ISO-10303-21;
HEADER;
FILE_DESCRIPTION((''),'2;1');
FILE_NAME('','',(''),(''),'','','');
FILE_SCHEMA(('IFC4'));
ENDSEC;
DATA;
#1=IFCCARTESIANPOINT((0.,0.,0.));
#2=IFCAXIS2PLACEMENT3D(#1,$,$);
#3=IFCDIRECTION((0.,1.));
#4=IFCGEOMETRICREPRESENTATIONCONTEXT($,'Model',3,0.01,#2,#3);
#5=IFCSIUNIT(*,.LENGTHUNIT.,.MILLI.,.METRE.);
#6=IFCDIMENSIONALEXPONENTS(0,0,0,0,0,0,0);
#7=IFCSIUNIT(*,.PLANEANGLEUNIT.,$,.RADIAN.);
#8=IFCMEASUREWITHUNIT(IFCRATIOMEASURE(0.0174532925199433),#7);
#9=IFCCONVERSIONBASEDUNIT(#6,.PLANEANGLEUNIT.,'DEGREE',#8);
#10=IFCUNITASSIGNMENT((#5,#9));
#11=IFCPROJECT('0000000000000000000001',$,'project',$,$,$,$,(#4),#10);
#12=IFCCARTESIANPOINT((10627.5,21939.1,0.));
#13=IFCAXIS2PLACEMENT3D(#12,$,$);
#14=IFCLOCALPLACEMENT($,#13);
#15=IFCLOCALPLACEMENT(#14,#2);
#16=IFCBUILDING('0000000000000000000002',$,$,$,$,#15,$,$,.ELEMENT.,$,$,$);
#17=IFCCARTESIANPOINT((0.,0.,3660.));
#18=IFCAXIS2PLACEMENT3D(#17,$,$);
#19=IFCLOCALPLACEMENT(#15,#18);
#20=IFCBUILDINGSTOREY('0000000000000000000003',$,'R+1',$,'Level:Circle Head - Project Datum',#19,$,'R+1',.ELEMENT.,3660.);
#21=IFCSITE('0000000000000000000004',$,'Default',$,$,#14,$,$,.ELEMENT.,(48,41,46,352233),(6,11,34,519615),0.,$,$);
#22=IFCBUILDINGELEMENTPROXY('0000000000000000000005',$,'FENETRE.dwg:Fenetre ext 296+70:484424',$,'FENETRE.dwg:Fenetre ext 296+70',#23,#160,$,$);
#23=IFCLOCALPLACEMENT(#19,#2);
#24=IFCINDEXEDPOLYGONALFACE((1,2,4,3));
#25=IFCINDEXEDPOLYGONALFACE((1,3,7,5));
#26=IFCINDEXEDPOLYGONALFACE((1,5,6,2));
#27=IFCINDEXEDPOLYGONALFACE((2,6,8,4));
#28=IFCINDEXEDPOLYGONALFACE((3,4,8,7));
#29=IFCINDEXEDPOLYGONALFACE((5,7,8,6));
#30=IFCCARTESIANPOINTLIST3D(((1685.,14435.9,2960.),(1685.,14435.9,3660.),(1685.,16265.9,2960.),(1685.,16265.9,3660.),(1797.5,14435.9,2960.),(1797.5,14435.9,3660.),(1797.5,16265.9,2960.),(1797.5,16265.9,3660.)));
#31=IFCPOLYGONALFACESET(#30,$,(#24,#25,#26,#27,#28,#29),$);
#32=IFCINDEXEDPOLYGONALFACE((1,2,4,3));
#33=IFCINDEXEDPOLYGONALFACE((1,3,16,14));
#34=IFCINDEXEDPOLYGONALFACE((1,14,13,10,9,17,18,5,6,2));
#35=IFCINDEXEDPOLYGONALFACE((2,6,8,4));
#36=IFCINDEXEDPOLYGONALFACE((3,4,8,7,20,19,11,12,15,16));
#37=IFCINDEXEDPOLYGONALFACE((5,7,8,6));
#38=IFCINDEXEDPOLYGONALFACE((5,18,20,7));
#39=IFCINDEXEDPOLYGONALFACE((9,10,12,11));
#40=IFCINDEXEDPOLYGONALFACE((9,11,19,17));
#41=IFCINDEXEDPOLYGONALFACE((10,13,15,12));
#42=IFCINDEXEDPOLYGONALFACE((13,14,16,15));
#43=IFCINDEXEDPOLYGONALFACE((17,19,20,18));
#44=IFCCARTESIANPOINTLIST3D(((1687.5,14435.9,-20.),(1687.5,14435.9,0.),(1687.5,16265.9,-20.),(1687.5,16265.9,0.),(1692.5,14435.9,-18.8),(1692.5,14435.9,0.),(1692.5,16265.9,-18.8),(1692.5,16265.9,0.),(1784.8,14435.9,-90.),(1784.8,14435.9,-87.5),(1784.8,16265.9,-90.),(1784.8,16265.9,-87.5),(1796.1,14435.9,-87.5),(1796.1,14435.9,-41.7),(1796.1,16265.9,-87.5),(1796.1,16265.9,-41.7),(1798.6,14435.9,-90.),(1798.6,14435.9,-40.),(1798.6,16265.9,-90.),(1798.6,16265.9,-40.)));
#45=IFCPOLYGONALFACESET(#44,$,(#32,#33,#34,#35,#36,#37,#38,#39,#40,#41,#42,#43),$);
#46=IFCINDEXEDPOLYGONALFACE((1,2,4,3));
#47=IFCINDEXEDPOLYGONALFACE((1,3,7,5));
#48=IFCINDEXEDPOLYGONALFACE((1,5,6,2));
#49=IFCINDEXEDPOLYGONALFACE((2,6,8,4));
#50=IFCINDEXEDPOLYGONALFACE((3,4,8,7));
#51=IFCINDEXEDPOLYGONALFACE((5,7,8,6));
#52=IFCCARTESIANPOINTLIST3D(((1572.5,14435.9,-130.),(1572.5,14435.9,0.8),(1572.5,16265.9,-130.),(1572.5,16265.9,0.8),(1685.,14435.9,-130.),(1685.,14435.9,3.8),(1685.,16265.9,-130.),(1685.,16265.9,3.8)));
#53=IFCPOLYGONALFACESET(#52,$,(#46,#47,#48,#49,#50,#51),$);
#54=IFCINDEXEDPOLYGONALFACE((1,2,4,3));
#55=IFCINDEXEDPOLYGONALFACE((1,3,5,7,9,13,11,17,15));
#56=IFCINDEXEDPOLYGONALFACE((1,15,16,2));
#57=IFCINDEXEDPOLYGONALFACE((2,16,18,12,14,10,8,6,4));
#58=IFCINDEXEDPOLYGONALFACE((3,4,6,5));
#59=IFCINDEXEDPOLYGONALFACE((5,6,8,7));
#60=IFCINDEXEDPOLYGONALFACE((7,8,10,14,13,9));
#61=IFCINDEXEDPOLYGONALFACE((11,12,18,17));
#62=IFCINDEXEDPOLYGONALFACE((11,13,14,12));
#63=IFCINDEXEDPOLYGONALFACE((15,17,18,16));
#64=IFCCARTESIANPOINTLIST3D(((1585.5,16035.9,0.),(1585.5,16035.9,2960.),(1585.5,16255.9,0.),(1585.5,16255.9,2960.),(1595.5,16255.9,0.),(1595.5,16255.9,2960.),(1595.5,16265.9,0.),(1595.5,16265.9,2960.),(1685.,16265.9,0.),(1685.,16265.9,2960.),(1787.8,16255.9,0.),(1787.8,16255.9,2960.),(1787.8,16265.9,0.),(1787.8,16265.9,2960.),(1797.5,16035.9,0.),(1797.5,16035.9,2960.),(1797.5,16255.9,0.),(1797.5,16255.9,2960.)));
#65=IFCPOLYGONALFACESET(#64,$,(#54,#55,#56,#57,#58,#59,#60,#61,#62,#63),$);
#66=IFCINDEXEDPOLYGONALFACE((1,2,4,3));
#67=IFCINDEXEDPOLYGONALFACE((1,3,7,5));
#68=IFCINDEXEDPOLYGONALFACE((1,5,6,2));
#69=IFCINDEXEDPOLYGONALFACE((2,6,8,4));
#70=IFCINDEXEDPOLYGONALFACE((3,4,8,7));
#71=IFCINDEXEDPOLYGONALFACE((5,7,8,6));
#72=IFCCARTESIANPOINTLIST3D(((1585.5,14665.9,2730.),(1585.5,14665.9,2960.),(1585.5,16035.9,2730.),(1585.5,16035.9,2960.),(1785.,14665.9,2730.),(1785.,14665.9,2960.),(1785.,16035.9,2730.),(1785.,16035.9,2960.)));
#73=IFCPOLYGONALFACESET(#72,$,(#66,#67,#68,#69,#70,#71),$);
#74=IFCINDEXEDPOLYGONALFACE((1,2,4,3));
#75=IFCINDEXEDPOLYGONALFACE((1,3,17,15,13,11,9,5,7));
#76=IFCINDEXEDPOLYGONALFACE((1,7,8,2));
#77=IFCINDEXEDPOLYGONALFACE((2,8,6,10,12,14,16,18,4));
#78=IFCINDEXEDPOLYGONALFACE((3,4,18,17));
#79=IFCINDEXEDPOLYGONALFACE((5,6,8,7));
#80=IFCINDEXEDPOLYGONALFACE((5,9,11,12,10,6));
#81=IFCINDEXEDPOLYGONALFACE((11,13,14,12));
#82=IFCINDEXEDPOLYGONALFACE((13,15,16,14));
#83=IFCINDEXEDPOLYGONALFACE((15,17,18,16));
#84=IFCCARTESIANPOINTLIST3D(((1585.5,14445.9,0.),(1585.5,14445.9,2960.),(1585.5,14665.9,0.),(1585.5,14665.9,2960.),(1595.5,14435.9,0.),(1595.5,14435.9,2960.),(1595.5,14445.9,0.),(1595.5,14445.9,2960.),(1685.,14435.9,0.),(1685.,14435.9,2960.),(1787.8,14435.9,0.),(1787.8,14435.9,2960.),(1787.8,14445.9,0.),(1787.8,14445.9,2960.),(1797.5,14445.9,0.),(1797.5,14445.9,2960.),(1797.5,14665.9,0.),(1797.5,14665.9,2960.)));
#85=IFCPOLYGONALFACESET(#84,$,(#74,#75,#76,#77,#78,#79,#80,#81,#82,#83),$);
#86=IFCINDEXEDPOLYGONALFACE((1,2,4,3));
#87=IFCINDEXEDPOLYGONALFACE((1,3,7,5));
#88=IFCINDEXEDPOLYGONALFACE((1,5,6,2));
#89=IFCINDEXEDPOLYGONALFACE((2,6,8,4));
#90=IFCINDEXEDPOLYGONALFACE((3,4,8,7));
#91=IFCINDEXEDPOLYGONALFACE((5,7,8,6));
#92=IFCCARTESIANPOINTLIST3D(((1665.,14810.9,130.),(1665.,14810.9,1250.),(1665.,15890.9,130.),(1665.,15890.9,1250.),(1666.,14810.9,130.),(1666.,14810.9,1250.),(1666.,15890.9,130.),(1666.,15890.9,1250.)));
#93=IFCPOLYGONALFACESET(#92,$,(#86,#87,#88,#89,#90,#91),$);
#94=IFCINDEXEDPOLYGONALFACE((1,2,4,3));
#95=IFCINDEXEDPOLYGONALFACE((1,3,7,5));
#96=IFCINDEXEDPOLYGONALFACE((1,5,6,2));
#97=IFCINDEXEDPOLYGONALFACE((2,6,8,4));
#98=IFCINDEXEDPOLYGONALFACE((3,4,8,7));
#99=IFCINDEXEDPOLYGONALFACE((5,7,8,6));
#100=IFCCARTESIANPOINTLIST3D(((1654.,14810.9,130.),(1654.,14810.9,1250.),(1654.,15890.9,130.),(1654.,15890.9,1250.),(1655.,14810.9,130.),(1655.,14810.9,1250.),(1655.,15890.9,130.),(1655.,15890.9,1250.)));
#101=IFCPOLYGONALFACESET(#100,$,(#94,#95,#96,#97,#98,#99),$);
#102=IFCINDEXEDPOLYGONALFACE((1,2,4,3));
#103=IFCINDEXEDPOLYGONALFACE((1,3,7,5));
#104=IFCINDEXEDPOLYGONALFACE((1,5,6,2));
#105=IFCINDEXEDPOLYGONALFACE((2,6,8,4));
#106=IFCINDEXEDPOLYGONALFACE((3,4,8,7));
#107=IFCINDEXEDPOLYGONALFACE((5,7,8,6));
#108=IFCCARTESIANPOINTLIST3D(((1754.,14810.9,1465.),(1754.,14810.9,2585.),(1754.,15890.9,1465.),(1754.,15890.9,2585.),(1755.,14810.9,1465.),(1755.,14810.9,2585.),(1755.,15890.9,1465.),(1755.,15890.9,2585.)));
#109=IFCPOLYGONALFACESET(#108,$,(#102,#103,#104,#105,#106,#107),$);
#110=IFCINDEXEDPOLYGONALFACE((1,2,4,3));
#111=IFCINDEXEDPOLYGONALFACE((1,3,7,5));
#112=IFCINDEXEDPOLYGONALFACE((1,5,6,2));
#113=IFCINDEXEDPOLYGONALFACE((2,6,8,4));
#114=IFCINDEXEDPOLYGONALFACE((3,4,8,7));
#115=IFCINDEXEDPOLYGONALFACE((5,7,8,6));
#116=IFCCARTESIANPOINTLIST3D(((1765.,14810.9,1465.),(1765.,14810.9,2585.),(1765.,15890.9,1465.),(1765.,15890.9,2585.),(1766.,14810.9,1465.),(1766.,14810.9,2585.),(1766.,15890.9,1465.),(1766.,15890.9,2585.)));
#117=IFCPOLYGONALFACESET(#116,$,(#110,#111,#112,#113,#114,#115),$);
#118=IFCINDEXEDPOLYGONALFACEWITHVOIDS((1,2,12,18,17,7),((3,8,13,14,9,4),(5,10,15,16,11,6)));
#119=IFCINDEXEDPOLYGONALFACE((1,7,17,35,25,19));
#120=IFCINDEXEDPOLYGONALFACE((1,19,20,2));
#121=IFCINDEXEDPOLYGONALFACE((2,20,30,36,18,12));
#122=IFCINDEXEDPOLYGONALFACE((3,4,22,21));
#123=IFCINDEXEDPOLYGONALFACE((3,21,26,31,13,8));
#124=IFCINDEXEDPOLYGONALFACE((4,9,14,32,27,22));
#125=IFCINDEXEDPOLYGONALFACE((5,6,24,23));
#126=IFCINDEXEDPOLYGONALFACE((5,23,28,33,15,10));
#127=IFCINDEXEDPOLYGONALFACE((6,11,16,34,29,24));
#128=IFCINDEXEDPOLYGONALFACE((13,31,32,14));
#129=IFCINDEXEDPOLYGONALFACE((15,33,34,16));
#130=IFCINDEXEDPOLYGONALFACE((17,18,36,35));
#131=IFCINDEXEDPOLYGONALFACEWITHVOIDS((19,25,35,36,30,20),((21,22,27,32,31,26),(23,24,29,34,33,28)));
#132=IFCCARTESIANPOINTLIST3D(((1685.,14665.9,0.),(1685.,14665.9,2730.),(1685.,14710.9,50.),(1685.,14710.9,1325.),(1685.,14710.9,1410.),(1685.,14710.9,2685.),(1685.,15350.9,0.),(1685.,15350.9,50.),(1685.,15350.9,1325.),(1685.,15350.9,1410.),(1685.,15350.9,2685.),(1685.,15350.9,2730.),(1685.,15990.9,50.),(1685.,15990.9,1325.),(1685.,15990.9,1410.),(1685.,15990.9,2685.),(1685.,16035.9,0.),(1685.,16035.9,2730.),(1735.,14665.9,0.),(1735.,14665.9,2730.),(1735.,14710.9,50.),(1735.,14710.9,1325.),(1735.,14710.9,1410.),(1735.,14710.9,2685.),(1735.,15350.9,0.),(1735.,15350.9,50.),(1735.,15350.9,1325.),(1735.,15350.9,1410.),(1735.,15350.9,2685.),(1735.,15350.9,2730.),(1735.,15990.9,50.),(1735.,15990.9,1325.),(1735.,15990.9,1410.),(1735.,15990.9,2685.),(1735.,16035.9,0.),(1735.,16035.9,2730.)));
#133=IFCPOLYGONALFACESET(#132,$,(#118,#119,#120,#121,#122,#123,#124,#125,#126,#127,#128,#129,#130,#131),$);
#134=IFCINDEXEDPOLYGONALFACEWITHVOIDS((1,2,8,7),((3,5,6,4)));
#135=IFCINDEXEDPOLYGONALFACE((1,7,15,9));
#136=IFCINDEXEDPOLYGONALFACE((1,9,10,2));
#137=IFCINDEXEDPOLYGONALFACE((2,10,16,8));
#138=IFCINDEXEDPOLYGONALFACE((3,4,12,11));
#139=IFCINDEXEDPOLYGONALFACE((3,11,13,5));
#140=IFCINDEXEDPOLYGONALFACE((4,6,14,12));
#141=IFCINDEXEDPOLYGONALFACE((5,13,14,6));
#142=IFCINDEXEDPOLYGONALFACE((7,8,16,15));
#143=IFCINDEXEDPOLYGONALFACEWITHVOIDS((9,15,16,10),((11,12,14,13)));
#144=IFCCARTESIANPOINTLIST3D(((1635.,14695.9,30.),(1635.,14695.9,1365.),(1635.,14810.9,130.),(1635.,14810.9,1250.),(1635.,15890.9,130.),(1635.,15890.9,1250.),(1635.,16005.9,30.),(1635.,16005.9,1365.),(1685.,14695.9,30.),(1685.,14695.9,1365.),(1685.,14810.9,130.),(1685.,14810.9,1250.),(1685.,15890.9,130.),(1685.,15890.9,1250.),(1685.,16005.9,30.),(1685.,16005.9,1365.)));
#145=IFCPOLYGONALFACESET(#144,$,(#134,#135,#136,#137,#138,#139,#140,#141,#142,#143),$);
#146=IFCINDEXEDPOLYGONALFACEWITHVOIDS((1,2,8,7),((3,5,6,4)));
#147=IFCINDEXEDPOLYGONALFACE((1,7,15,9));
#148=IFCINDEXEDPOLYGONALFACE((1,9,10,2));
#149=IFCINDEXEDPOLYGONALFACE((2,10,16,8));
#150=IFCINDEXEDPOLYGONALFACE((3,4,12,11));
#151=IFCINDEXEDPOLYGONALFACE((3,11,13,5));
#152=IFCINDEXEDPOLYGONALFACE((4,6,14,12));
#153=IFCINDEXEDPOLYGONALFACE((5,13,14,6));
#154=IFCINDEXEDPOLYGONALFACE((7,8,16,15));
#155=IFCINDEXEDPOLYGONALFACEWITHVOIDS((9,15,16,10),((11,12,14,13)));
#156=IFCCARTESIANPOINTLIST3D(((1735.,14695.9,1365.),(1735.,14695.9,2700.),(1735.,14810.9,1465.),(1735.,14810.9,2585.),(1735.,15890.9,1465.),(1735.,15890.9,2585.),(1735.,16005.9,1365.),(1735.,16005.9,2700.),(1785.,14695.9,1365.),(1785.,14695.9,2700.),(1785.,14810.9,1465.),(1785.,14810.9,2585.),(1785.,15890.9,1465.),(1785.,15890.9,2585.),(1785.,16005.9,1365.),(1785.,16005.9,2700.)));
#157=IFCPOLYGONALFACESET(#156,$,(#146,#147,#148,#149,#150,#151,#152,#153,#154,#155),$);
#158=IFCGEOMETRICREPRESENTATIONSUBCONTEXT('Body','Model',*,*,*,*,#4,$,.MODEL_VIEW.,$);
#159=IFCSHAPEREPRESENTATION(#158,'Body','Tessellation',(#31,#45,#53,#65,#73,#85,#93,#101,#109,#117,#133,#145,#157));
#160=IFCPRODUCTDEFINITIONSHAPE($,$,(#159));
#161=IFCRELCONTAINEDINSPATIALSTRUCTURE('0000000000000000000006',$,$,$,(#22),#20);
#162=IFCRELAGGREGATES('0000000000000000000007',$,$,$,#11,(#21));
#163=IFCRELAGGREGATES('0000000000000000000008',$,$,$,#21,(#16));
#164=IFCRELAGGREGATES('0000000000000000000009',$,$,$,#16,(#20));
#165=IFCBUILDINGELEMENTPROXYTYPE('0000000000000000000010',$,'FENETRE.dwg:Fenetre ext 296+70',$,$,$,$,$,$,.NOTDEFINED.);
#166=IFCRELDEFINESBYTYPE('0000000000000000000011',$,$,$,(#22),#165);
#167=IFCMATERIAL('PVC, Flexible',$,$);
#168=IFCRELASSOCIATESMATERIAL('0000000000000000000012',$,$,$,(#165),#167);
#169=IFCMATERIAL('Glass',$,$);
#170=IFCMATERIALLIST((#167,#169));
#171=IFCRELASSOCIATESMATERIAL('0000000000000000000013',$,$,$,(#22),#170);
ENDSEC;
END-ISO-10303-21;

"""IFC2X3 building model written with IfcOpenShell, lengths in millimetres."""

from ifc_helpers import new_model, entity, si_unit, converted_unit, direction, frame, frame_2d, origin, origin_2d_with_axis, place, context, subcontext, project, spatial, polyline, rectangle, outline, extrude, source, transform, mapped, material, material_list, type_object, type_shapes, element, save


model = new_model("IFC2X3")

# Units and contexts
model_context = context("Model", 3, precision=0.01, world=origin(), true_north=direction((0.0, 1.0)))
body_context = subcontext(model_context, "Body", "Model", "MODEL_VIEW")
ifc_project = project(units=[si_unit("LENGTHUNIT", "METRE", prefix="MILLI"), converted_unit("PLANEANGLEUNIT", "DEGREE", entity("IfcRatioMeasure", 0.0174532925199433), si_unit("PLANEANGLEUNIT", "RADIAN"), dimensions=[0, 0, 0, 0, 0, 0, 0])], contexts=[model_context])

# Site, building, storey
site_placement = place(None, frame((10627.5, 21939.1, 0.0)))
site = spatial("IfcSite", under=ifc_project, at=site_placement, Name="Default", CompositionType="ELEMENT", RefLatitude=(48, 41, 46, 352233), RefLongitude=(6, 11, 34, 519615), RefElevation=0.0)
building_placement = place(site_placement, origin())
building = spatial("IfcBuilding", under=site, at=building_placement, CompositionType="ELEMENT")
storey_placement = place(building_placement, frame((0.0, 0.0, 3660.0)))
storey = spatial("IfcBuildingStorey", under=building, at=storey_placement, Name="R+1", ObjectType="Level:Circle Head - Project Datum", LongName="R+1", CompositionType="ELEMENT", Elevation=3660.0)

# Building element proxy
ifc_material_1 = material(Name="PVC, Flexible")
ifc_material_2 = material(Name="Glass")
ifc_material_list_1 = material_list([ifc_material_1, ifc_material_2])
building_element_proxy_type_1 = type_object("IfcBuildingElementProxyType", Name="FENETRE.dwg:Fenetre ext 296+70", PredefinedType="NOTDEFINED", material=ifc_material_1)
shared_shape_1 = source(origin(), body_context, "Body", "SweptSolid", [
    extrude(rectangle(XDim=112.5, YDim=1830.0, at=origin_2d_with_axis()), frame((-10.4, -56.3, 2960.0), z_axis=(0.0, 0.0, 1.0), x_axis=(0.0, 1.0, 0.0)), (0.0, 0.0, 1.0), 700.0),
    extrude(outline(polyline([(27.5, -64.4), (47.5, -64.4), (47.5, -59.4), (28.8, -59.4), (7.5, 46.7), (-42.5, 46.7), (-42.5, 32.9), (-40.0, 32.9), (-40.0, 44.2), (5.8, 44.2), (27.5, -64.4)])), frame((-925.4, -66.9, -47.5), z_axis=(1.0, 0.0, 0.0), x_axis=(0.0, 0.0, 1.0)), (0.0, 0.0, 1.0), 1830.0),
    extrude(outline(polyline([(-54.5, -66.1), (58.0, -66.1), (54.5, 67.6), (-58.0, 64.6), (-54.5, -66.1)])), frame((-925.4, 56.3, -63.8), z_axis=(1.0, 0.0, 0.0), x_axis=(0.0, -0.999645, 0.02665)), (0.0, 0.0, 1.0), 1830.0),
    extrude(outline(polyline([(-97.0, -55.6), (5.9, -55.6), (95.4, -55.6), (95.4, -45.6), (105.4, -45.6), (105.4, 174.4), (-106.6, 174.4), (-106.6, -45.6), (-97.0, -45.6), (-97.0, -55.6)])), frame((849.0, -5.9, 0.0), z_axis=(0.0, 0.0, 1.0), x_axis=(0.0, 1.0, 0.0)), (0.0, 0.0, 1.0), 2960.0),
    extrude(rectangle(XDim=1370.0, YDim=199.5, at=origin_2d_with_axis()), frame((-10.4, -0.3, 2730.0), z_axis=(0.0, 0.0, 1.0), x_axis=(-1.0, 0.0, 0.0)), (0.0, 0.0, 1.0), 230.0),
    extrude(outline(polyline([(-55.6, 97.0), (-55.6, -5.9), (-55.6, -95.4), (-45.6, -95.4), (-45.6, -105.4), (174.4, -105.4), (174.4, 106.6), (-45.6, 106.6), (-45.6, 97.0), (-55.6, 97.0)])), frame((-869.9, -5.9, 0.0), z_axis=(0.0, 0.0, -1.0), x_axis=(1.0, 0.0, 0.0)), (0.0, 0.0, -1.0), 2960.0),
    extrude(rectangle(XDim=1080.0, YDim=1.0, at=origin_2d_with_axis()), frame((-10.4, 19.5, 130.0), z_axis=(0.0, 0.0, 1.0), x_axis=(-1.0, 0.0, 0.0)), (0.0, 0.0, 1.0), 1120.0),
    extrude(rectangle(XDim=1080.0, YDim=1.0, at=origin_2d_with_axis()), frame((-10.4, 30.5, 130.0), z_axis=(0.0, 0.0, 1.0), x_axis=(-1.0, 0.0, 0.0)), (0.0, 0.0, 1.0), 1120.0),
    extrude(rectangle(XDim=1080.0, YDim=1.0, at=frame_2d((0.0, 0.0), x_axis=(1.0, 0.0))), frame((-10.4, -69.5, 1465.0), z_axis=(0.0, 0.0, 1.0), x_axis=(-1.0, 0.0, 0.0)), (0.0, 0.0, 1.0), 1120.0),
    extrude(rectangle(XDim=1080.0, YDim=1.0, at=frame_2d((0.0, 0.0), x_axis=(1.0, 0.0))), frame((-10.4, -80.5, 1465.0), z_axis=(0.0, 0.0, 1.0), x_axis=(-1.0, 0.0, 0.0)), (0.0, 0.0, 1.0), 1120.0),
    extrude(outline(polyline([(-685.0, -1365.0), (0.0, -1365.0), (685.0, -1365.0), (685.0, 1365.0), (0.0, 1365.0), (-685.0, 1365.0), (-685.0, -1365.0)]), holes=[polyline([(-640.0, -1320.0), (-640.0, -45.0), (0.0, -45.0), (640.0, -45.0), (640.0, -1320.0), (0.0, -1320.0), (-640.0, -1320.0)]), polyline([(-640.0, 40.0), (-640.0, 1315.0), (0.0, 1315.0), (640.0, 1315.0), (640.0, 40.0), (0.0, 40.0), (-640.0, 40.0)])]), frame((-10.4, -50.0, 1365.0), z_axis=(0.0, 1.0, 0.0), x_axis=(1.0, 0.0, 0.0)), (0.0, 0.0, 1.0), 50.0),
    extrude(outline(polyline([(-655.0, -667.5), (655.0, -667.5), (655.0, 667.5), (-655.0, 667.5), (-655.0, -667.5)]), holes=[polyline([(-540.0, 552.5), (540.0, 552.5), (540.0, -567.5), (-540.0, -567.5), (-540.0, 552.5)])]), frame((-10.4, 0.0, 697.5), z_axis=(0.0, 1.0, 0.0), x_axis=(-1.0, 0.0, 0.0)), (0.0, 0.0, 1.0), 50.0),
    extrude(outline(polyline([(-655.0, -667.5), (655.0, -667.5), (655.0, 667.5), (-655.0, 667.5), (-655.0, -667.5)]), holes=[polyline([(-540.0, 552.5), (540.0, 552.5), (540.0, -567.5), (-540.0, -567.5), (-540.0, 552.5)])]), frame((-10.4, -100.0, 2032.5), z_axis=(0.0, 1.0, 0.0), x_axis=(-1.0, 0.0, 0.0)), (0.0, 0.0, 1.0), 50.0),
])
type_shapes(building_element_proxy_type_1, [shared_shape_1])
proxy_1_placement = place(storey_placement, frame((1685.0, 15361.3, 0.0), z_axis=(0.0, 0.0, 1.0), x_axis=(0.0, 1.0, 0.0)))
element("IfcBuildingElementProxy", 1, at=proxy_1_placement, inside=storey, type_object=building_element_proxy_type_1, material=ifc_material_list_1, Name="FENETRE.dwg:Fenetre ext 296+70:484424", ObjectType="FENETRE.dwg:Fenetre ext 296+70", context=body_context, shape_type="MappedRepresentation", body=[
    mapped(shared_shape_1, transform((0.0, 0.0, 0.0), scale=1.0)),
])

save(model, "model.ifc")
